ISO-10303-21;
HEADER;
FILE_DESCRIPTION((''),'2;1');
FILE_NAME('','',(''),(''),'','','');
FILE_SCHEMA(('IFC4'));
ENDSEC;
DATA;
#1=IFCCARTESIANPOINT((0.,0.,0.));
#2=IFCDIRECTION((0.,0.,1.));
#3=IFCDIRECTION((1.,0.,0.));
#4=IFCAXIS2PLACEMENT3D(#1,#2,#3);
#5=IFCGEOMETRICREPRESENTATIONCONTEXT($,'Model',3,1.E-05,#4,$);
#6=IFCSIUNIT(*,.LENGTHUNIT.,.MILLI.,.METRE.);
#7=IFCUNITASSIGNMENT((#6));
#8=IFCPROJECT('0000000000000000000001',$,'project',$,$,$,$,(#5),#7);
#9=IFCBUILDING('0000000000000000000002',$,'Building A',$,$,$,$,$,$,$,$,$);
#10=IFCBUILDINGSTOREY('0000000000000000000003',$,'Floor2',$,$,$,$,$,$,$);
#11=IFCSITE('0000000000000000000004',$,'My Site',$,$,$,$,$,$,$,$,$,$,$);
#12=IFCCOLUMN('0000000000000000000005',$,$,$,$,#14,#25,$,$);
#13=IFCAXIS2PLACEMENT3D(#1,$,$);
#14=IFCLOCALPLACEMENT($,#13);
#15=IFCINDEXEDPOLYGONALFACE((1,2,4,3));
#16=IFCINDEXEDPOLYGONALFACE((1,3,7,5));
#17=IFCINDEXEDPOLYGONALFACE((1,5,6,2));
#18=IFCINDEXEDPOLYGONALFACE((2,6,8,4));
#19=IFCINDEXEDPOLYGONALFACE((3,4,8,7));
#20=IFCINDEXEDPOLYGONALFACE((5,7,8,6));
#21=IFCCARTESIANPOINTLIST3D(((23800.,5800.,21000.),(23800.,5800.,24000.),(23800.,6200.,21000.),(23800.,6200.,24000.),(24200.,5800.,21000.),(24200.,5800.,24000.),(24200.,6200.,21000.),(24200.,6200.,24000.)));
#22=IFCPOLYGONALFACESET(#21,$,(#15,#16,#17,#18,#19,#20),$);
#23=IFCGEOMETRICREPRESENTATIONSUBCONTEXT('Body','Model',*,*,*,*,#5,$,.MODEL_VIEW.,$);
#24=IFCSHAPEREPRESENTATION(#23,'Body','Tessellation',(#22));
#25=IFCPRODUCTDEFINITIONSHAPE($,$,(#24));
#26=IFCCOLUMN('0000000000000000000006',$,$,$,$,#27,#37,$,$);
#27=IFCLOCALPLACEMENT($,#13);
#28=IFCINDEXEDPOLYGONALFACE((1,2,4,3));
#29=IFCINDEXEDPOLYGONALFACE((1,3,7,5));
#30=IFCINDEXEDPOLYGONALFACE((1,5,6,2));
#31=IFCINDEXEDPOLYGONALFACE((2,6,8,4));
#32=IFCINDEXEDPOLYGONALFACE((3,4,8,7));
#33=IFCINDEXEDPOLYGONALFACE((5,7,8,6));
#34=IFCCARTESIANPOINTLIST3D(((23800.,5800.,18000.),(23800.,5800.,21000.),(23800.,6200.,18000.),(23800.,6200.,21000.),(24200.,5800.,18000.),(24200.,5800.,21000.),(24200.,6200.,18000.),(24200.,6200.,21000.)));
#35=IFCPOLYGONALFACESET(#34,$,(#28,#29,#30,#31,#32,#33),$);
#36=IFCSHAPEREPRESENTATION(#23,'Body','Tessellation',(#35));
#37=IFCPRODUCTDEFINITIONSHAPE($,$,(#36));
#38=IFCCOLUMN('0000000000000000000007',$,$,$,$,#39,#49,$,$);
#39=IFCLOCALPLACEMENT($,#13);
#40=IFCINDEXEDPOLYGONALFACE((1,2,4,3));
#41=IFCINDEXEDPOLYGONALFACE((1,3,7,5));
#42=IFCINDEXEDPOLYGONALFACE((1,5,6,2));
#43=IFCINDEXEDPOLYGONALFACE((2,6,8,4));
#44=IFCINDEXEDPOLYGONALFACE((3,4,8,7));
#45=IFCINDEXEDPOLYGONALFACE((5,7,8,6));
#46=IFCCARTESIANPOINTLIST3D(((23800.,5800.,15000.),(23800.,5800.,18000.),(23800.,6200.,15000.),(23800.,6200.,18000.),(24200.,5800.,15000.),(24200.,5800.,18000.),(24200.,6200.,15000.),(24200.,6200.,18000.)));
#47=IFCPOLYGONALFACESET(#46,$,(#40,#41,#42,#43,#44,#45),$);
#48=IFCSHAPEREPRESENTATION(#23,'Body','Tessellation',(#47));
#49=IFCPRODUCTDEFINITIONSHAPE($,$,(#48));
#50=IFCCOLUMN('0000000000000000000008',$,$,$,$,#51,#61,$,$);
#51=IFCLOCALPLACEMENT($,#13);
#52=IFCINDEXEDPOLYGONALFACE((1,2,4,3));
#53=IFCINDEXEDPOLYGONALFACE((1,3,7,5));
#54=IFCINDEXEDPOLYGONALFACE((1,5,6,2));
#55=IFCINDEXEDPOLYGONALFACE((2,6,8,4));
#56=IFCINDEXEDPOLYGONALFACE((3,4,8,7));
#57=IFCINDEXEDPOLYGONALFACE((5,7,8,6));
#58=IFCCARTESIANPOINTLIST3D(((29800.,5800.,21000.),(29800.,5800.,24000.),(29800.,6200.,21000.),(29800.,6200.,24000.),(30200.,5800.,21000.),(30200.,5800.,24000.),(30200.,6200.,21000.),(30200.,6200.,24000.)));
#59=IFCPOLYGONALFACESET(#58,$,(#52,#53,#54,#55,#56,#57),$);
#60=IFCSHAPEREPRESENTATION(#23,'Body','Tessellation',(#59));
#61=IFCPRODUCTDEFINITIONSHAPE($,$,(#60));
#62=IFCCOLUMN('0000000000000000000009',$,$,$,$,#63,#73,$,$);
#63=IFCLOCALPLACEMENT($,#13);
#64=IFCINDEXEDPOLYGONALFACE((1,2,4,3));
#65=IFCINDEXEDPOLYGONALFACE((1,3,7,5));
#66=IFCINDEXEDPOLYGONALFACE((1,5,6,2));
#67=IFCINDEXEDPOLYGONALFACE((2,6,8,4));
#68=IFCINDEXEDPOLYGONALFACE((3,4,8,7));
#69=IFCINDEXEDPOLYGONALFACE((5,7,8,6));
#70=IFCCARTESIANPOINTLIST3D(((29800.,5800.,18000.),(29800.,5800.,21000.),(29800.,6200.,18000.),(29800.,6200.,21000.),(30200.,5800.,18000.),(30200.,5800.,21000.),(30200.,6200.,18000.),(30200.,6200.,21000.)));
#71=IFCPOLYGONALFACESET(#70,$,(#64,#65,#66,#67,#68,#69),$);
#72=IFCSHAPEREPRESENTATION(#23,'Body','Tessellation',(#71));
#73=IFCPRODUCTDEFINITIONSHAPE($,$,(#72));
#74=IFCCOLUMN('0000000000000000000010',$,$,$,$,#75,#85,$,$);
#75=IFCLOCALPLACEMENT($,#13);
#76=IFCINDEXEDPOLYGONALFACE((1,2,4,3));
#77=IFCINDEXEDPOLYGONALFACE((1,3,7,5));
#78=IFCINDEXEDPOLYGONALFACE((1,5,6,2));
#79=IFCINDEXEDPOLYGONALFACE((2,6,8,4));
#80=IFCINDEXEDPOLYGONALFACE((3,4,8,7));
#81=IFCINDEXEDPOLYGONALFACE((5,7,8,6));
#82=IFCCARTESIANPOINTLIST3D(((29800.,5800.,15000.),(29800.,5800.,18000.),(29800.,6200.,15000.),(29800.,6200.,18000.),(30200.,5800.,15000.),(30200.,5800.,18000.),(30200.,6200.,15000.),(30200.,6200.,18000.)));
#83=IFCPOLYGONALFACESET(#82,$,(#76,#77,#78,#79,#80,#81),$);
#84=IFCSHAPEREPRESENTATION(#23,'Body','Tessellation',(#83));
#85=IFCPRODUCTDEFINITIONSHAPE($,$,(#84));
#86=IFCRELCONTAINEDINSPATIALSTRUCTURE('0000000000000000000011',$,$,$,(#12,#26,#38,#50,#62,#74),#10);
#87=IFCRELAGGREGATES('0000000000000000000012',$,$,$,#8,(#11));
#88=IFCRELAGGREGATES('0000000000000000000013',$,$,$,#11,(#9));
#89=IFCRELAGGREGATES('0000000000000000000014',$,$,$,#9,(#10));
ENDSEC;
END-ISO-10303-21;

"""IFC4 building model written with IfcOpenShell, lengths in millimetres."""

from ifc_helpers import new_model, si_unit, frame, origin_with_axes, place, context, subcontext, project, spatial, line, indexed_curve, outline, extrude, element, save


model = new_model("IFC4")

# Units and contexts
model_context = context("Model", 3, precision=1e-05, world=origin_with_axes())
body_context = subcontext(model_context, "Body", "Model", "MODEL_VIEW")
ifc_project = project(units=[si_unit("LENGTHUNIT", "METRE", prefix="MILLI")], contexts=[model_context])

# Site, building, storey
site = spatial("IfcSite", under=ifc_project, Name="My Site")
building = spatial("IfcBuilding", under=site, Name="Building A")
storey = spatial("IfcBuildingStorey", under=building, Name="Floor2")

# Columns
for number, where, z_axis, x_axis in (
    (1, (24000.0, 6000.0, 21000.0), (0.0, 0.0, 1.0), (1.0, 0.0, 0.0)),
    (2, (24000.0, 6000.0, 18000.0), (0.0, 0.0, 1.0), (1.0, 0.0, 0.0)),
    (3, (24000.0, 6000.0, 15000.0), (0.0, 0.0, 1.0), (1.0, 0.0, 0.0)),
    (4, (30000.0, 6000.0, 21000.0), (0.0, 0.0, 1.0), (1.0, 0.0, 0.0)),
    (5, (30000.0, 6000.0, 18000.0), (0.0, 0.0, 1.0), (1.0, 0.0, 0.0)),
    (6, (30000.0, 6000.0, 15000.0), (0.0, 0.0, 1.0), (1.0, 0.0, 0.0)),
):
    element("IfcColumn", number, at=place(None, frame(where, z_axis=z_axis, x_axis=x_axis)), inside=storey, context=body_context, shape_type="SweptSolid", body=[
        extrude(outline(indexed_curve([(-200.0, -200.0), (200.0, -200.0), (200.0, 200.0), (-200.0, 200.0)], segments=[line(1, 2, 3, 4, 1)])), origin_with_axes(), (0.0, 0.0, 1.0), 3000.0),
    ])

save(model, "model.ifc")
